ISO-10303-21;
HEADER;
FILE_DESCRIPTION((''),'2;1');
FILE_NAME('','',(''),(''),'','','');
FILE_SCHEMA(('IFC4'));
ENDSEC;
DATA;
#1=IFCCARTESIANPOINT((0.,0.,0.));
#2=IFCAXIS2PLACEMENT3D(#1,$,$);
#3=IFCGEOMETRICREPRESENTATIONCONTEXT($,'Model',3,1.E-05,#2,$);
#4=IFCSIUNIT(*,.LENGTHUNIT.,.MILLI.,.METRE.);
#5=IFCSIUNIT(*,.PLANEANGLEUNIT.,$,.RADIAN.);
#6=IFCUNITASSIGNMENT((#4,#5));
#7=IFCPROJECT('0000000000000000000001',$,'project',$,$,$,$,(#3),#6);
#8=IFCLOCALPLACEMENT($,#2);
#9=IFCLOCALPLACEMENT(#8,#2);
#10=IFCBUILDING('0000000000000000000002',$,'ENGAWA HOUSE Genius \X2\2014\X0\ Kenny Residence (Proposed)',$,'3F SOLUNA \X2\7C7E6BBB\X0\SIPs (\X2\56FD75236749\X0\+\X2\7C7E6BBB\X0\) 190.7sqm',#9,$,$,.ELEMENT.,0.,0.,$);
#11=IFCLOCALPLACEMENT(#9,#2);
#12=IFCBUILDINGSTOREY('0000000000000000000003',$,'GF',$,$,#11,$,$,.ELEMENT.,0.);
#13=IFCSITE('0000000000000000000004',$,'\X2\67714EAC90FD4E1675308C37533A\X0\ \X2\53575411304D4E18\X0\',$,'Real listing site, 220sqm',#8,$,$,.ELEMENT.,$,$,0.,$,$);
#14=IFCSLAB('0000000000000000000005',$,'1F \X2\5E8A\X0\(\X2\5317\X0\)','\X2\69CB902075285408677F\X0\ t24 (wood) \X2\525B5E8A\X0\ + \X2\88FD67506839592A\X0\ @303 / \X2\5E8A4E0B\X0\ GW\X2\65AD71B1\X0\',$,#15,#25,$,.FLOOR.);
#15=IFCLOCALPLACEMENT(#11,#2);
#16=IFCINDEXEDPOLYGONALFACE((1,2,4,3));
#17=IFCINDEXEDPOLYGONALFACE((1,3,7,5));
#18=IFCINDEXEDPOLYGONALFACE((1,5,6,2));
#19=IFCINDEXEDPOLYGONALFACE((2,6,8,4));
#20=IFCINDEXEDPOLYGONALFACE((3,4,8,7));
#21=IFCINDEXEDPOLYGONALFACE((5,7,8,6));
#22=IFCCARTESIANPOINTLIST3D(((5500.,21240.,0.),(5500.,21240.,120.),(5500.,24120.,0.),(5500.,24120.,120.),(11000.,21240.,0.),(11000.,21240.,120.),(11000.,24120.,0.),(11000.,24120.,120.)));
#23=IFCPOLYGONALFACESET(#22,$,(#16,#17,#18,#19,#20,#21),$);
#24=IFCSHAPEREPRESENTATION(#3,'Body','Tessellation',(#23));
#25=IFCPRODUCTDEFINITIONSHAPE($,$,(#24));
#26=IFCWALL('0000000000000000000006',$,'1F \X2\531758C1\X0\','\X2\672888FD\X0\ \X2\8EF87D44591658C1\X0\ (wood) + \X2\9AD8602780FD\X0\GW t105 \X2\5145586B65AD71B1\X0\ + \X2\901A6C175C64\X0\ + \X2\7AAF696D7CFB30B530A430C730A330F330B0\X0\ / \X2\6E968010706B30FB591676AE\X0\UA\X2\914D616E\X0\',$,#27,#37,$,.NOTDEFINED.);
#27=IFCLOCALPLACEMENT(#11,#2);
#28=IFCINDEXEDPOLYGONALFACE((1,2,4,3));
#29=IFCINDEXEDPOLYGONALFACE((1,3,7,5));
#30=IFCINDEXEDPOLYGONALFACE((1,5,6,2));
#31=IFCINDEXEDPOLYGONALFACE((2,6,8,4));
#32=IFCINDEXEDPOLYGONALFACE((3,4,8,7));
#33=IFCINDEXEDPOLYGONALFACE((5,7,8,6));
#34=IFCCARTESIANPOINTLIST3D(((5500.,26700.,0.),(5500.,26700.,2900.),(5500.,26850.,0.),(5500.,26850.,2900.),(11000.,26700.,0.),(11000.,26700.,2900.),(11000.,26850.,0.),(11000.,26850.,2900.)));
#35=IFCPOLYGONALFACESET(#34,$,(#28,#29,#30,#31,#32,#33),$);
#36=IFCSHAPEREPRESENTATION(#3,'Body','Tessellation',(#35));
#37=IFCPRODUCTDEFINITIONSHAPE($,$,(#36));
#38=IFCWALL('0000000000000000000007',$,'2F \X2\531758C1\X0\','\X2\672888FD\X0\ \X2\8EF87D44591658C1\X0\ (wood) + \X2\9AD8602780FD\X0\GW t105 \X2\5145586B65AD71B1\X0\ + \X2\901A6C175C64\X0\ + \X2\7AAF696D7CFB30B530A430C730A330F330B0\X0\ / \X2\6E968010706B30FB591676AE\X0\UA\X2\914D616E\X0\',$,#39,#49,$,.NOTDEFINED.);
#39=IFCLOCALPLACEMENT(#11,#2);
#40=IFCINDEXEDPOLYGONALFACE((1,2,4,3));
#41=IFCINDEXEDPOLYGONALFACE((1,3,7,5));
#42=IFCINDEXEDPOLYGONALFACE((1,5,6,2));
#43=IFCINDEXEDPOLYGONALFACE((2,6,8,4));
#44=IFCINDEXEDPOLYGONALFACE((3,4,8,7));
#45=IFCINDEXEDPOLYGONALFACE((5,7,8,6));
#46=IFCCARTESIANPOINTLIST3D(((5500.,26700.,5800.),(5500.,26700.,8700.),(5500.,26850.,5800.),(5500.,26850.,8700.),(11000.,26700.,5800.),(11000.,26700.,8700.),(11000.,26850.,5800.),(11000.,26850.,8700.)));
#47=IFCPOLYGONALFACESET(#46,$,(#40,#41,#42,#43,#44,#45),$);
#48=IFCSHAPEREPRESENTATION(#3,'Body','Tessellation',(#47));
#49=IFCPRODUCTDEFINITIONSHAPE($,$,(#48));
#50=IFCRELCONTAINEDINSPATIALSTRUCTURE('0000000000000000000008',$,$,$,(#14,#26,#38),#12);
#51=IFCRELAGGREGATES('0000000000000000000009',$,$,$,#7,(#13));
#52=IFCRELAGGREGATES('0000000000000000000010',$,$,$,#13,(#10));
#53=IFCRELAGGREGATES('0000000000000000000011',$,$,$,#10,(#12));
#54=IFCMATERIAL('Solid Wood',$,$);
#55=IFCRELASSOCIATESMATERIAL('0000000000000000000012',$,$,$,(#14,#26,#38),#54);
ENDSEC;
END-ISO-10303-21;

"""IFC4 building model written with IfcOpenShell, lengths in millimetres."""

from ifc_helpers import new_model, si_unit, frame, frame_2d, origin, place, context, project, spatial, rectangle, extrude, material, element, save


model = new_model("IFC4")

# Units and contexts
model_context = context("Model", 3, precision=1e-05, world=origin())
ifc_project = project(units=[si_unit("LENGTHUNIT", "METRE", prefix="MILLI"), si_unit("PLANEANGLEUNIT", "RADIAN")], contexts=[model_context])

# Site, building, storey
site_placement = place(None, origin())
site = spatial("IfcSite", under=ifc_project, at=site_placement, Name="東京都世田谷区 南向き丘", ObjectType="Real listing site, 220sqm", CompositionType="ELEMENT", RefElevation=0.0)
building_placement = place(site_placement, origin())
building = spatial("IfcBuilding", under=site, at=building_placement, Name="ENGAWA HOUSE Genius — Kenny Residence (Proposed)", ObjectType="3F SOLUNA 籾殻SIPs (国産杉+籾殻) 190.7sqm", CompositionType="ELEMENT", ElevationOfRefHeight=0.0, ElevationOfTerrain=0.0)
storey_placement = place(building_placement, origin())
storey = spatial("IfcBuildingStorey", under=building, at=storey_placement, Name="GF", CompositionType="ELEMENT", Elevation=0.0)

# Slab
ifc_material_1 = material(Name="Solid Wood")
slab_1_placement = place(storey_placement, frame((2750.0, 10620.0, 0.0)))
element("IfcSlab", 1, at=slab_1_placement, inside=storey, material=ifc_material_1, Name="1F 床(北)", Description="構造用合板 t24 (wood) 剛床 + 製材根太 @303 / 床下 GW断熱", PredefinedType="FLOOR", context=model_context, shape_type="SweptSolid", body=[
    extrude(rectangle(XDim=5500.0, YDim=2880.0, at=frame_2d((2750.0, 1440.0))), frame((2750.0, 10620.0, 0.0)), (0.0, 0.0, 1.0), 120.0),
])

# Wall
wall_1_placement = place(storey_placement, frame((2750.0, 13350.0, 0.0)))
element("IfcWall", 2, at=wall_1_placement, inside=storey, material=ifc_material_1, Name="1F 北壁", Description="木製 軸組外壁 (wood) + 高性能GW t105 充填断熱 + 通気層 + 窯業系サイディング / 準耐火・外皮UA配慮", PredefinedType="NOTDEFINED", context=model_context, shape_type="SweptSolid", body=[
    extrude(rectangle(XDim=5500.0, YDim=150.0, at=frame_2d((2750.0, 75.0))), frame((2750.0, 13350.0, 0.0)), (0.0, 0.0, 1.0), 2900.0),
])

# Wall
wall_2_placement = place(storey_placement, frame((2750.0, 13350.0, 2900.0)))
element("IfcWall", 3, at=wall_2_placement, inside=storey, material=ifc_material_1, Name="2F 北壁", Description="木製 軸組外壁 (wood) + 高性能GW t105 充填断熱 + 通気層 + 窯業系サイディング / 準耐火・外皮UA配慮", PredefinedType="NOTDEFINED", context=model_context, shape_type="SweptSolid", body=[
    extrude(rectangle(XDim=5500.0, YDim=150.0, at=frame_2d((2750.0, 75.0))), frame((2750.0, 13350.0, 2900.0)), (0.0, 0.0, 1.0), 2900.0),
])

save(model, "model.ifc")
